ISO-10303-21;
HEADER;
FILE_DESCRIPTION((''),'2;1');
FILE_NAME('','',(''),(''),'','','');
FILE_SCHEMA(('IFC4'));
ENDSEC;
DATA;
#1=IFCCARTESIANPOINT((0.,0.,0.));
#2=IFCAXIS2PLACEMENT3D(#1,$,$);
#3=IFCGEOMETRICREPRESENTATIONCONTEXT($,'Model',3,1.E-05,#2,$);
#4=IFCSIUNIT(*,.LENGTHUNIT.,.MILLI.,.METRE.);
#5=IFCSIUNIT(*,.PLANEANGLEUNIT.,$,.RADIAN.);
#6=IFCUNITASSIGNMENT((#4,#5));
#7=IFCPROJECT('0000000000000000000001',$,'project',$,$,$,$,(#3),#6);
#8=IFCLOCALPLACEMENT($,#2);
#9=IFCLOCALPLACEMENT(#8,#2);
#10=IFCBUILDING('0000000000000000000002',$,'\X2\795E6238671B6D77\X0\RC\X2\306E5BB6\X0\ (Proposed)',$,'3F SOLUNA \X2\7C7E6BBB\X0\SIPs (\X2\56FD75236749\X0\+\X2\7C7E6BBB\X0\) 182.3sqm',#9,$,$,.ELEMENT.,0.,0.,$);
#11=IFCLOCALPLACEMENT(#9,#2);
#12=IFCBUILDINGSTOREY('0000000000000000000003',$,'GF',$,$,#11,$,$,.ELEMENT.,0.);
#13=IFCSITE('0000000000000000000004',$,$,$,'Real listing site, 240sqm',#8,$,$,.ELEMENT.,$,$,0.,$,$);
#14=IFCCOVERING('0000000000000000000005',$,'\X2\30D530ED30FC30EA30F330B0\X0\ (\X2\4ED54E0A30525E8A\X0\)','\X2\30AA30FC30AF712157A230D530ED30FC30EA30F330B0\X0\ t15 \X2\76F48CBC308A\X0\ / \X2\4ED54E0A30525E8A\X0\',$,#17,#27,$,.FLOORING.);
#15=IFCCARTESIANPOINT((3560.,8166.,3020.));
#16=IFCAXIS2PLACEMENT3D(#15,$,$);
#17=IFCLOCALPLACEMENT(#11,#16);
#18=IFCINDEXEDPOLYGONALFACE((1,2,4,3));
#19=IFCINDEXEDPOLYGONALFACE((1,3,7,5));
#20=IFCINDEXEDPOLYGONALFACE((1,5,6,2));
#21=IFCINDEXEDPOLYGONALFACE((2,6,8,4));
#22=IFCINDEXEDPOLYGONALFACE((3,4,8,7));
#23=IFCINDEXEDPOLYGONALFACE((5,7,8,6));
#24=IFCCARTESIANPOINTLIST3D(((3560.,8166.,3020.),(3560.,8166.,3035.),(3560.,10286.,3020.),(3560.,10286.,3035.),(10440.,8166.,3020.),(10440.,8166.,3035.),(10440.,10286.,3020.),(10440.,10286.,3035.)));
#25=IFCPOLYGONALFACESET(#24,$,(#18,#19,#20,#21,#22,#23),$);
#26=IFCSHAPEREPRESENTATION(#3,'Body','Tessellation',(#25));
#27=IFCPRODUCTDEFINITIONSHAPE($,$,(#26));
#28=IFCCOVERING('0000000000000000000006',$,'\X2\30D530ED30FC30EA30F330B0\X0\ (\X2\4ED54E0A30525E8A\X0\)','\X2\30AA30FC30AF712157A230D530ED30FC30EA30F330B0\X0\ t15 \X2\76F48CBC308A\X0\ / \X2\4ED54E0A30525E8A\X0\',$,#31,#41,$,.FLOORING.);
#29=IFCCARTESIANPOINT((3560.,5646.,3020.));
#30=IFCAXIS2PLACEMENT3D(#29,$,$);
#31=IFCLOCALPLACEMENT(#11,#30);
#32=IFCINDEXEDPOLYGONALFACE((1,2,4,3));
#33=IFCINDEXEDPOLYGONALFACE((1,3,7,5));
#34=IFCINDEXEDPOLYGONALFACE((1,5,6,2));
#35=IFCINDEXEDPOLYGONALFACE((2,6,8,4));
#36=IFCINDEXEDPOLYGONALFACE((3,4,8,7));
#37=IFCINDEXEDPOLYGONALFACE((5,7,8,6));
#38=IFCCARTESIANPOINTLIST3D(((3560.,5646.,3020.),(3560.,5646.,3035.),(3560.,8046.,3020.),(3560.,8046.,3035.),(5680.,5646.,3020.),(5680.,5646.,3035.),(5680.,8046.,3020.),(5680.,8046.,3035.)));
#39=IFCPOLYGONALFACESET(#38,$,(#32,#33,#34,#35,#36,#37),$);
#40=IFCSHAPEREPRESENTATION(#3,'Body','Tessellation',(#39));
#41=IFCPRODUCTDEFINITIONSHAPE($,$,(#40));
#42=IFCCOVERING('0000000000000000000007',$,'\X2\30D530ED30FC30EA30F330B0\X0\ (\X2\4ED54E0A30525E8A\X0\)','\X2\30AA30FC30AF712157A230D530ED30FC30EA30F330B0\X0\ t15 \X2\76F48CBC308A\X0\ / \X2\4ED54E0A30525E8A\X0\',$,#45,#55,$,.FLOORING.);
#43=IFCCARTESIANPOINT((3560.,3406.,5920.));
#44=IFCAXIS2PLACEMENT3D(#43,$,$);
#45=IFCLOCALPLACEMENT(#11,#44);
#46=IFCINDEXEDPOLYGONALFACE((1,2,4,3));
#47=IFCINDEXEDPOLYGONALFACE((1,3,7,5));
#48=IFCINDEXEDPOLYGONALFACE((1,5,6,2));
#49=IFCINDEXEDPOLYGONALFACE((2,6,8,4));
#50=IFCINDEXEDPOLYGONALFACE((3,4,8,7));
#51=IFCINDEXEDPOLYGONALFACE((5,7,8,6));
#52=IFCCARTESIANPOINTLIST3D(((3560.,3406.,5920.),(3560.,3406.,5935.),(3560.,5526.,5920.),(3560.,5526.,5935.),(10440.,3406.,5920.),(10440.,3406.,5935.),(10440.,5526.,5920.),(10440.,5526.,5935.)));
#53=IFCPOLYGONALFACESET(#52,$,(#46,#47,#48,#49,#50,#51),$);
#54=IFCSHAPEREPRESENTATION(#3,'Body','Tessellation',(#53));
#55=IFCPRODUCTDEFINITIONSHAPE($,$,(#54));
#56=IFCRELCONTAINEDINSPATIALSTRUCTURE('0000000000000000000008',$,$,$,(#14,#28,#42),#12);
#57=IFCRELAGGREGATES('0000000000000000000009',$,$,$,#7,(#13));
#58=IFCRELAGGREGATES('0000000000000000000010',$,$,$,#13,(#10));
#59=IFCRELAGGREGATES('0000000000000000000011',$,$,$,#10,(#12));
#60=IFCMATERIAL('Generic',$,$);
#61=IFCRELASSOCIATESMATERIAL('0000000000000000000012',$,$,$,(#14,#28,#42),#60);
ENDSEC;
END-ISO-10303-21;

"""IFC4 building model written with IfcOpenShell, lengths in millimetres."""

from ifc_helpers import new_model, si_unit, frame, frame_2d, origin, place, context, project, spatial, rectangle, extrude, material, element, save


model = new_model("IFC4")

# Units and contexts
model_context = context("Model", 3, precision=1e-05, world=origin())
ifc_project = project(units=[si_unit("LENGTHUNIT", "METRE", prefix="MILLI"), si_unit("PLANEANGLEUNIT", "RADIAN")], contexts=[model_context])

# Site, building, storey
site_placement = place(None, origin())
site = spatial("IfcSite", under=ifc_project, at=site_placement, ObjectType="Real listing site, 240sqm", CompositionType="ELEMENT", RefElevation=0.0)
building_placement = place(site_placement, origin())
building = spatial("IfcBuilding", under=site, at=building_placement, Name="神戸望海RCの家 (Proposed)", ObjectType="3F SOLUNA 籾殻SIPs (国産杉+籾殻) 182.3sqm", CompositionType="ELEMENT", ElevationOfRefHeight=0.0, ElevationOfTerrain=0.0)
storey_placement = place(building_placement, origin())
storey = spatial("IfcBuildingStorey", under=building, at=storey_placement, Name="GF", CompositionType="ELEMENT", Elevation=0.0)

# Shared definitions
ifc_material_1 = material(Name="Generic")

# Coverings
covering_1_placement = place(storey_placement, frame((3560.0, 8166.0, 3020.0)))
element("IfcCovering", 1, at=covering_1_placement, inside=storey, material=ifc_material_1, Name="フローリング (仕上げ床)", Description="オーク無垢フローリング t15 直貼り / 仕上げ床", PredefinedType="FLOORING", context=model_context, shape_type="SweptSolid", body=[
    extrude(rectangle(XDim=6880.0, YDim=2120.0, at=frame_2d((3440.0, 1060.0))), frame((3560.0, 8166.0, 3020.0)), (0.0, 0.0, 1.0), 15.0),
])
covering_2_placement = place(storey_placement, frame((3560.0, 5646.0, 3020.0)))
element("IfcCovering", 2, at=covering_2_placement, inside=storey, material=ifc_material_1, Name="フローリング (仕上げ床)", Description="オーク無垢フローリング t15 直貼り / 仕上げ床", PredefinedType="FLOORING", context=model_context, shape_type="SweptSolid", body=[
    extrude(rectangle(XDim=2120.0, YDim=2400.0, at=frame_2d((1060.0, 1200.0))), frame((3560.0, 5646.0, 3020.0)), (0.0, 0.0, 1.0), 15.0),
])
covering_3_placement = place(storey_placement, frame((3560.0, 3406.0, 5920.0)))
element("IfcCovering", 3, at=covering_3_placement, inside=storey, material=ifc_material_1, Name="フローリング (仕上げ床)", Description="オーク無垢フローリング t15 直貼り / 仕上げ床", PredefinedType="FLOORING", context=model_context, shape_type="SweptSolid", body=[
    extrude(rectangle(XDim=6880.0, YDim=2120.0, at=frame_2d((3440.0, 1060.0))), frame((3560.0, 3406.0, 5920.0)), (0.0, 0.0, 1.0), 15.0),
])

save(model, "model.ifc")
